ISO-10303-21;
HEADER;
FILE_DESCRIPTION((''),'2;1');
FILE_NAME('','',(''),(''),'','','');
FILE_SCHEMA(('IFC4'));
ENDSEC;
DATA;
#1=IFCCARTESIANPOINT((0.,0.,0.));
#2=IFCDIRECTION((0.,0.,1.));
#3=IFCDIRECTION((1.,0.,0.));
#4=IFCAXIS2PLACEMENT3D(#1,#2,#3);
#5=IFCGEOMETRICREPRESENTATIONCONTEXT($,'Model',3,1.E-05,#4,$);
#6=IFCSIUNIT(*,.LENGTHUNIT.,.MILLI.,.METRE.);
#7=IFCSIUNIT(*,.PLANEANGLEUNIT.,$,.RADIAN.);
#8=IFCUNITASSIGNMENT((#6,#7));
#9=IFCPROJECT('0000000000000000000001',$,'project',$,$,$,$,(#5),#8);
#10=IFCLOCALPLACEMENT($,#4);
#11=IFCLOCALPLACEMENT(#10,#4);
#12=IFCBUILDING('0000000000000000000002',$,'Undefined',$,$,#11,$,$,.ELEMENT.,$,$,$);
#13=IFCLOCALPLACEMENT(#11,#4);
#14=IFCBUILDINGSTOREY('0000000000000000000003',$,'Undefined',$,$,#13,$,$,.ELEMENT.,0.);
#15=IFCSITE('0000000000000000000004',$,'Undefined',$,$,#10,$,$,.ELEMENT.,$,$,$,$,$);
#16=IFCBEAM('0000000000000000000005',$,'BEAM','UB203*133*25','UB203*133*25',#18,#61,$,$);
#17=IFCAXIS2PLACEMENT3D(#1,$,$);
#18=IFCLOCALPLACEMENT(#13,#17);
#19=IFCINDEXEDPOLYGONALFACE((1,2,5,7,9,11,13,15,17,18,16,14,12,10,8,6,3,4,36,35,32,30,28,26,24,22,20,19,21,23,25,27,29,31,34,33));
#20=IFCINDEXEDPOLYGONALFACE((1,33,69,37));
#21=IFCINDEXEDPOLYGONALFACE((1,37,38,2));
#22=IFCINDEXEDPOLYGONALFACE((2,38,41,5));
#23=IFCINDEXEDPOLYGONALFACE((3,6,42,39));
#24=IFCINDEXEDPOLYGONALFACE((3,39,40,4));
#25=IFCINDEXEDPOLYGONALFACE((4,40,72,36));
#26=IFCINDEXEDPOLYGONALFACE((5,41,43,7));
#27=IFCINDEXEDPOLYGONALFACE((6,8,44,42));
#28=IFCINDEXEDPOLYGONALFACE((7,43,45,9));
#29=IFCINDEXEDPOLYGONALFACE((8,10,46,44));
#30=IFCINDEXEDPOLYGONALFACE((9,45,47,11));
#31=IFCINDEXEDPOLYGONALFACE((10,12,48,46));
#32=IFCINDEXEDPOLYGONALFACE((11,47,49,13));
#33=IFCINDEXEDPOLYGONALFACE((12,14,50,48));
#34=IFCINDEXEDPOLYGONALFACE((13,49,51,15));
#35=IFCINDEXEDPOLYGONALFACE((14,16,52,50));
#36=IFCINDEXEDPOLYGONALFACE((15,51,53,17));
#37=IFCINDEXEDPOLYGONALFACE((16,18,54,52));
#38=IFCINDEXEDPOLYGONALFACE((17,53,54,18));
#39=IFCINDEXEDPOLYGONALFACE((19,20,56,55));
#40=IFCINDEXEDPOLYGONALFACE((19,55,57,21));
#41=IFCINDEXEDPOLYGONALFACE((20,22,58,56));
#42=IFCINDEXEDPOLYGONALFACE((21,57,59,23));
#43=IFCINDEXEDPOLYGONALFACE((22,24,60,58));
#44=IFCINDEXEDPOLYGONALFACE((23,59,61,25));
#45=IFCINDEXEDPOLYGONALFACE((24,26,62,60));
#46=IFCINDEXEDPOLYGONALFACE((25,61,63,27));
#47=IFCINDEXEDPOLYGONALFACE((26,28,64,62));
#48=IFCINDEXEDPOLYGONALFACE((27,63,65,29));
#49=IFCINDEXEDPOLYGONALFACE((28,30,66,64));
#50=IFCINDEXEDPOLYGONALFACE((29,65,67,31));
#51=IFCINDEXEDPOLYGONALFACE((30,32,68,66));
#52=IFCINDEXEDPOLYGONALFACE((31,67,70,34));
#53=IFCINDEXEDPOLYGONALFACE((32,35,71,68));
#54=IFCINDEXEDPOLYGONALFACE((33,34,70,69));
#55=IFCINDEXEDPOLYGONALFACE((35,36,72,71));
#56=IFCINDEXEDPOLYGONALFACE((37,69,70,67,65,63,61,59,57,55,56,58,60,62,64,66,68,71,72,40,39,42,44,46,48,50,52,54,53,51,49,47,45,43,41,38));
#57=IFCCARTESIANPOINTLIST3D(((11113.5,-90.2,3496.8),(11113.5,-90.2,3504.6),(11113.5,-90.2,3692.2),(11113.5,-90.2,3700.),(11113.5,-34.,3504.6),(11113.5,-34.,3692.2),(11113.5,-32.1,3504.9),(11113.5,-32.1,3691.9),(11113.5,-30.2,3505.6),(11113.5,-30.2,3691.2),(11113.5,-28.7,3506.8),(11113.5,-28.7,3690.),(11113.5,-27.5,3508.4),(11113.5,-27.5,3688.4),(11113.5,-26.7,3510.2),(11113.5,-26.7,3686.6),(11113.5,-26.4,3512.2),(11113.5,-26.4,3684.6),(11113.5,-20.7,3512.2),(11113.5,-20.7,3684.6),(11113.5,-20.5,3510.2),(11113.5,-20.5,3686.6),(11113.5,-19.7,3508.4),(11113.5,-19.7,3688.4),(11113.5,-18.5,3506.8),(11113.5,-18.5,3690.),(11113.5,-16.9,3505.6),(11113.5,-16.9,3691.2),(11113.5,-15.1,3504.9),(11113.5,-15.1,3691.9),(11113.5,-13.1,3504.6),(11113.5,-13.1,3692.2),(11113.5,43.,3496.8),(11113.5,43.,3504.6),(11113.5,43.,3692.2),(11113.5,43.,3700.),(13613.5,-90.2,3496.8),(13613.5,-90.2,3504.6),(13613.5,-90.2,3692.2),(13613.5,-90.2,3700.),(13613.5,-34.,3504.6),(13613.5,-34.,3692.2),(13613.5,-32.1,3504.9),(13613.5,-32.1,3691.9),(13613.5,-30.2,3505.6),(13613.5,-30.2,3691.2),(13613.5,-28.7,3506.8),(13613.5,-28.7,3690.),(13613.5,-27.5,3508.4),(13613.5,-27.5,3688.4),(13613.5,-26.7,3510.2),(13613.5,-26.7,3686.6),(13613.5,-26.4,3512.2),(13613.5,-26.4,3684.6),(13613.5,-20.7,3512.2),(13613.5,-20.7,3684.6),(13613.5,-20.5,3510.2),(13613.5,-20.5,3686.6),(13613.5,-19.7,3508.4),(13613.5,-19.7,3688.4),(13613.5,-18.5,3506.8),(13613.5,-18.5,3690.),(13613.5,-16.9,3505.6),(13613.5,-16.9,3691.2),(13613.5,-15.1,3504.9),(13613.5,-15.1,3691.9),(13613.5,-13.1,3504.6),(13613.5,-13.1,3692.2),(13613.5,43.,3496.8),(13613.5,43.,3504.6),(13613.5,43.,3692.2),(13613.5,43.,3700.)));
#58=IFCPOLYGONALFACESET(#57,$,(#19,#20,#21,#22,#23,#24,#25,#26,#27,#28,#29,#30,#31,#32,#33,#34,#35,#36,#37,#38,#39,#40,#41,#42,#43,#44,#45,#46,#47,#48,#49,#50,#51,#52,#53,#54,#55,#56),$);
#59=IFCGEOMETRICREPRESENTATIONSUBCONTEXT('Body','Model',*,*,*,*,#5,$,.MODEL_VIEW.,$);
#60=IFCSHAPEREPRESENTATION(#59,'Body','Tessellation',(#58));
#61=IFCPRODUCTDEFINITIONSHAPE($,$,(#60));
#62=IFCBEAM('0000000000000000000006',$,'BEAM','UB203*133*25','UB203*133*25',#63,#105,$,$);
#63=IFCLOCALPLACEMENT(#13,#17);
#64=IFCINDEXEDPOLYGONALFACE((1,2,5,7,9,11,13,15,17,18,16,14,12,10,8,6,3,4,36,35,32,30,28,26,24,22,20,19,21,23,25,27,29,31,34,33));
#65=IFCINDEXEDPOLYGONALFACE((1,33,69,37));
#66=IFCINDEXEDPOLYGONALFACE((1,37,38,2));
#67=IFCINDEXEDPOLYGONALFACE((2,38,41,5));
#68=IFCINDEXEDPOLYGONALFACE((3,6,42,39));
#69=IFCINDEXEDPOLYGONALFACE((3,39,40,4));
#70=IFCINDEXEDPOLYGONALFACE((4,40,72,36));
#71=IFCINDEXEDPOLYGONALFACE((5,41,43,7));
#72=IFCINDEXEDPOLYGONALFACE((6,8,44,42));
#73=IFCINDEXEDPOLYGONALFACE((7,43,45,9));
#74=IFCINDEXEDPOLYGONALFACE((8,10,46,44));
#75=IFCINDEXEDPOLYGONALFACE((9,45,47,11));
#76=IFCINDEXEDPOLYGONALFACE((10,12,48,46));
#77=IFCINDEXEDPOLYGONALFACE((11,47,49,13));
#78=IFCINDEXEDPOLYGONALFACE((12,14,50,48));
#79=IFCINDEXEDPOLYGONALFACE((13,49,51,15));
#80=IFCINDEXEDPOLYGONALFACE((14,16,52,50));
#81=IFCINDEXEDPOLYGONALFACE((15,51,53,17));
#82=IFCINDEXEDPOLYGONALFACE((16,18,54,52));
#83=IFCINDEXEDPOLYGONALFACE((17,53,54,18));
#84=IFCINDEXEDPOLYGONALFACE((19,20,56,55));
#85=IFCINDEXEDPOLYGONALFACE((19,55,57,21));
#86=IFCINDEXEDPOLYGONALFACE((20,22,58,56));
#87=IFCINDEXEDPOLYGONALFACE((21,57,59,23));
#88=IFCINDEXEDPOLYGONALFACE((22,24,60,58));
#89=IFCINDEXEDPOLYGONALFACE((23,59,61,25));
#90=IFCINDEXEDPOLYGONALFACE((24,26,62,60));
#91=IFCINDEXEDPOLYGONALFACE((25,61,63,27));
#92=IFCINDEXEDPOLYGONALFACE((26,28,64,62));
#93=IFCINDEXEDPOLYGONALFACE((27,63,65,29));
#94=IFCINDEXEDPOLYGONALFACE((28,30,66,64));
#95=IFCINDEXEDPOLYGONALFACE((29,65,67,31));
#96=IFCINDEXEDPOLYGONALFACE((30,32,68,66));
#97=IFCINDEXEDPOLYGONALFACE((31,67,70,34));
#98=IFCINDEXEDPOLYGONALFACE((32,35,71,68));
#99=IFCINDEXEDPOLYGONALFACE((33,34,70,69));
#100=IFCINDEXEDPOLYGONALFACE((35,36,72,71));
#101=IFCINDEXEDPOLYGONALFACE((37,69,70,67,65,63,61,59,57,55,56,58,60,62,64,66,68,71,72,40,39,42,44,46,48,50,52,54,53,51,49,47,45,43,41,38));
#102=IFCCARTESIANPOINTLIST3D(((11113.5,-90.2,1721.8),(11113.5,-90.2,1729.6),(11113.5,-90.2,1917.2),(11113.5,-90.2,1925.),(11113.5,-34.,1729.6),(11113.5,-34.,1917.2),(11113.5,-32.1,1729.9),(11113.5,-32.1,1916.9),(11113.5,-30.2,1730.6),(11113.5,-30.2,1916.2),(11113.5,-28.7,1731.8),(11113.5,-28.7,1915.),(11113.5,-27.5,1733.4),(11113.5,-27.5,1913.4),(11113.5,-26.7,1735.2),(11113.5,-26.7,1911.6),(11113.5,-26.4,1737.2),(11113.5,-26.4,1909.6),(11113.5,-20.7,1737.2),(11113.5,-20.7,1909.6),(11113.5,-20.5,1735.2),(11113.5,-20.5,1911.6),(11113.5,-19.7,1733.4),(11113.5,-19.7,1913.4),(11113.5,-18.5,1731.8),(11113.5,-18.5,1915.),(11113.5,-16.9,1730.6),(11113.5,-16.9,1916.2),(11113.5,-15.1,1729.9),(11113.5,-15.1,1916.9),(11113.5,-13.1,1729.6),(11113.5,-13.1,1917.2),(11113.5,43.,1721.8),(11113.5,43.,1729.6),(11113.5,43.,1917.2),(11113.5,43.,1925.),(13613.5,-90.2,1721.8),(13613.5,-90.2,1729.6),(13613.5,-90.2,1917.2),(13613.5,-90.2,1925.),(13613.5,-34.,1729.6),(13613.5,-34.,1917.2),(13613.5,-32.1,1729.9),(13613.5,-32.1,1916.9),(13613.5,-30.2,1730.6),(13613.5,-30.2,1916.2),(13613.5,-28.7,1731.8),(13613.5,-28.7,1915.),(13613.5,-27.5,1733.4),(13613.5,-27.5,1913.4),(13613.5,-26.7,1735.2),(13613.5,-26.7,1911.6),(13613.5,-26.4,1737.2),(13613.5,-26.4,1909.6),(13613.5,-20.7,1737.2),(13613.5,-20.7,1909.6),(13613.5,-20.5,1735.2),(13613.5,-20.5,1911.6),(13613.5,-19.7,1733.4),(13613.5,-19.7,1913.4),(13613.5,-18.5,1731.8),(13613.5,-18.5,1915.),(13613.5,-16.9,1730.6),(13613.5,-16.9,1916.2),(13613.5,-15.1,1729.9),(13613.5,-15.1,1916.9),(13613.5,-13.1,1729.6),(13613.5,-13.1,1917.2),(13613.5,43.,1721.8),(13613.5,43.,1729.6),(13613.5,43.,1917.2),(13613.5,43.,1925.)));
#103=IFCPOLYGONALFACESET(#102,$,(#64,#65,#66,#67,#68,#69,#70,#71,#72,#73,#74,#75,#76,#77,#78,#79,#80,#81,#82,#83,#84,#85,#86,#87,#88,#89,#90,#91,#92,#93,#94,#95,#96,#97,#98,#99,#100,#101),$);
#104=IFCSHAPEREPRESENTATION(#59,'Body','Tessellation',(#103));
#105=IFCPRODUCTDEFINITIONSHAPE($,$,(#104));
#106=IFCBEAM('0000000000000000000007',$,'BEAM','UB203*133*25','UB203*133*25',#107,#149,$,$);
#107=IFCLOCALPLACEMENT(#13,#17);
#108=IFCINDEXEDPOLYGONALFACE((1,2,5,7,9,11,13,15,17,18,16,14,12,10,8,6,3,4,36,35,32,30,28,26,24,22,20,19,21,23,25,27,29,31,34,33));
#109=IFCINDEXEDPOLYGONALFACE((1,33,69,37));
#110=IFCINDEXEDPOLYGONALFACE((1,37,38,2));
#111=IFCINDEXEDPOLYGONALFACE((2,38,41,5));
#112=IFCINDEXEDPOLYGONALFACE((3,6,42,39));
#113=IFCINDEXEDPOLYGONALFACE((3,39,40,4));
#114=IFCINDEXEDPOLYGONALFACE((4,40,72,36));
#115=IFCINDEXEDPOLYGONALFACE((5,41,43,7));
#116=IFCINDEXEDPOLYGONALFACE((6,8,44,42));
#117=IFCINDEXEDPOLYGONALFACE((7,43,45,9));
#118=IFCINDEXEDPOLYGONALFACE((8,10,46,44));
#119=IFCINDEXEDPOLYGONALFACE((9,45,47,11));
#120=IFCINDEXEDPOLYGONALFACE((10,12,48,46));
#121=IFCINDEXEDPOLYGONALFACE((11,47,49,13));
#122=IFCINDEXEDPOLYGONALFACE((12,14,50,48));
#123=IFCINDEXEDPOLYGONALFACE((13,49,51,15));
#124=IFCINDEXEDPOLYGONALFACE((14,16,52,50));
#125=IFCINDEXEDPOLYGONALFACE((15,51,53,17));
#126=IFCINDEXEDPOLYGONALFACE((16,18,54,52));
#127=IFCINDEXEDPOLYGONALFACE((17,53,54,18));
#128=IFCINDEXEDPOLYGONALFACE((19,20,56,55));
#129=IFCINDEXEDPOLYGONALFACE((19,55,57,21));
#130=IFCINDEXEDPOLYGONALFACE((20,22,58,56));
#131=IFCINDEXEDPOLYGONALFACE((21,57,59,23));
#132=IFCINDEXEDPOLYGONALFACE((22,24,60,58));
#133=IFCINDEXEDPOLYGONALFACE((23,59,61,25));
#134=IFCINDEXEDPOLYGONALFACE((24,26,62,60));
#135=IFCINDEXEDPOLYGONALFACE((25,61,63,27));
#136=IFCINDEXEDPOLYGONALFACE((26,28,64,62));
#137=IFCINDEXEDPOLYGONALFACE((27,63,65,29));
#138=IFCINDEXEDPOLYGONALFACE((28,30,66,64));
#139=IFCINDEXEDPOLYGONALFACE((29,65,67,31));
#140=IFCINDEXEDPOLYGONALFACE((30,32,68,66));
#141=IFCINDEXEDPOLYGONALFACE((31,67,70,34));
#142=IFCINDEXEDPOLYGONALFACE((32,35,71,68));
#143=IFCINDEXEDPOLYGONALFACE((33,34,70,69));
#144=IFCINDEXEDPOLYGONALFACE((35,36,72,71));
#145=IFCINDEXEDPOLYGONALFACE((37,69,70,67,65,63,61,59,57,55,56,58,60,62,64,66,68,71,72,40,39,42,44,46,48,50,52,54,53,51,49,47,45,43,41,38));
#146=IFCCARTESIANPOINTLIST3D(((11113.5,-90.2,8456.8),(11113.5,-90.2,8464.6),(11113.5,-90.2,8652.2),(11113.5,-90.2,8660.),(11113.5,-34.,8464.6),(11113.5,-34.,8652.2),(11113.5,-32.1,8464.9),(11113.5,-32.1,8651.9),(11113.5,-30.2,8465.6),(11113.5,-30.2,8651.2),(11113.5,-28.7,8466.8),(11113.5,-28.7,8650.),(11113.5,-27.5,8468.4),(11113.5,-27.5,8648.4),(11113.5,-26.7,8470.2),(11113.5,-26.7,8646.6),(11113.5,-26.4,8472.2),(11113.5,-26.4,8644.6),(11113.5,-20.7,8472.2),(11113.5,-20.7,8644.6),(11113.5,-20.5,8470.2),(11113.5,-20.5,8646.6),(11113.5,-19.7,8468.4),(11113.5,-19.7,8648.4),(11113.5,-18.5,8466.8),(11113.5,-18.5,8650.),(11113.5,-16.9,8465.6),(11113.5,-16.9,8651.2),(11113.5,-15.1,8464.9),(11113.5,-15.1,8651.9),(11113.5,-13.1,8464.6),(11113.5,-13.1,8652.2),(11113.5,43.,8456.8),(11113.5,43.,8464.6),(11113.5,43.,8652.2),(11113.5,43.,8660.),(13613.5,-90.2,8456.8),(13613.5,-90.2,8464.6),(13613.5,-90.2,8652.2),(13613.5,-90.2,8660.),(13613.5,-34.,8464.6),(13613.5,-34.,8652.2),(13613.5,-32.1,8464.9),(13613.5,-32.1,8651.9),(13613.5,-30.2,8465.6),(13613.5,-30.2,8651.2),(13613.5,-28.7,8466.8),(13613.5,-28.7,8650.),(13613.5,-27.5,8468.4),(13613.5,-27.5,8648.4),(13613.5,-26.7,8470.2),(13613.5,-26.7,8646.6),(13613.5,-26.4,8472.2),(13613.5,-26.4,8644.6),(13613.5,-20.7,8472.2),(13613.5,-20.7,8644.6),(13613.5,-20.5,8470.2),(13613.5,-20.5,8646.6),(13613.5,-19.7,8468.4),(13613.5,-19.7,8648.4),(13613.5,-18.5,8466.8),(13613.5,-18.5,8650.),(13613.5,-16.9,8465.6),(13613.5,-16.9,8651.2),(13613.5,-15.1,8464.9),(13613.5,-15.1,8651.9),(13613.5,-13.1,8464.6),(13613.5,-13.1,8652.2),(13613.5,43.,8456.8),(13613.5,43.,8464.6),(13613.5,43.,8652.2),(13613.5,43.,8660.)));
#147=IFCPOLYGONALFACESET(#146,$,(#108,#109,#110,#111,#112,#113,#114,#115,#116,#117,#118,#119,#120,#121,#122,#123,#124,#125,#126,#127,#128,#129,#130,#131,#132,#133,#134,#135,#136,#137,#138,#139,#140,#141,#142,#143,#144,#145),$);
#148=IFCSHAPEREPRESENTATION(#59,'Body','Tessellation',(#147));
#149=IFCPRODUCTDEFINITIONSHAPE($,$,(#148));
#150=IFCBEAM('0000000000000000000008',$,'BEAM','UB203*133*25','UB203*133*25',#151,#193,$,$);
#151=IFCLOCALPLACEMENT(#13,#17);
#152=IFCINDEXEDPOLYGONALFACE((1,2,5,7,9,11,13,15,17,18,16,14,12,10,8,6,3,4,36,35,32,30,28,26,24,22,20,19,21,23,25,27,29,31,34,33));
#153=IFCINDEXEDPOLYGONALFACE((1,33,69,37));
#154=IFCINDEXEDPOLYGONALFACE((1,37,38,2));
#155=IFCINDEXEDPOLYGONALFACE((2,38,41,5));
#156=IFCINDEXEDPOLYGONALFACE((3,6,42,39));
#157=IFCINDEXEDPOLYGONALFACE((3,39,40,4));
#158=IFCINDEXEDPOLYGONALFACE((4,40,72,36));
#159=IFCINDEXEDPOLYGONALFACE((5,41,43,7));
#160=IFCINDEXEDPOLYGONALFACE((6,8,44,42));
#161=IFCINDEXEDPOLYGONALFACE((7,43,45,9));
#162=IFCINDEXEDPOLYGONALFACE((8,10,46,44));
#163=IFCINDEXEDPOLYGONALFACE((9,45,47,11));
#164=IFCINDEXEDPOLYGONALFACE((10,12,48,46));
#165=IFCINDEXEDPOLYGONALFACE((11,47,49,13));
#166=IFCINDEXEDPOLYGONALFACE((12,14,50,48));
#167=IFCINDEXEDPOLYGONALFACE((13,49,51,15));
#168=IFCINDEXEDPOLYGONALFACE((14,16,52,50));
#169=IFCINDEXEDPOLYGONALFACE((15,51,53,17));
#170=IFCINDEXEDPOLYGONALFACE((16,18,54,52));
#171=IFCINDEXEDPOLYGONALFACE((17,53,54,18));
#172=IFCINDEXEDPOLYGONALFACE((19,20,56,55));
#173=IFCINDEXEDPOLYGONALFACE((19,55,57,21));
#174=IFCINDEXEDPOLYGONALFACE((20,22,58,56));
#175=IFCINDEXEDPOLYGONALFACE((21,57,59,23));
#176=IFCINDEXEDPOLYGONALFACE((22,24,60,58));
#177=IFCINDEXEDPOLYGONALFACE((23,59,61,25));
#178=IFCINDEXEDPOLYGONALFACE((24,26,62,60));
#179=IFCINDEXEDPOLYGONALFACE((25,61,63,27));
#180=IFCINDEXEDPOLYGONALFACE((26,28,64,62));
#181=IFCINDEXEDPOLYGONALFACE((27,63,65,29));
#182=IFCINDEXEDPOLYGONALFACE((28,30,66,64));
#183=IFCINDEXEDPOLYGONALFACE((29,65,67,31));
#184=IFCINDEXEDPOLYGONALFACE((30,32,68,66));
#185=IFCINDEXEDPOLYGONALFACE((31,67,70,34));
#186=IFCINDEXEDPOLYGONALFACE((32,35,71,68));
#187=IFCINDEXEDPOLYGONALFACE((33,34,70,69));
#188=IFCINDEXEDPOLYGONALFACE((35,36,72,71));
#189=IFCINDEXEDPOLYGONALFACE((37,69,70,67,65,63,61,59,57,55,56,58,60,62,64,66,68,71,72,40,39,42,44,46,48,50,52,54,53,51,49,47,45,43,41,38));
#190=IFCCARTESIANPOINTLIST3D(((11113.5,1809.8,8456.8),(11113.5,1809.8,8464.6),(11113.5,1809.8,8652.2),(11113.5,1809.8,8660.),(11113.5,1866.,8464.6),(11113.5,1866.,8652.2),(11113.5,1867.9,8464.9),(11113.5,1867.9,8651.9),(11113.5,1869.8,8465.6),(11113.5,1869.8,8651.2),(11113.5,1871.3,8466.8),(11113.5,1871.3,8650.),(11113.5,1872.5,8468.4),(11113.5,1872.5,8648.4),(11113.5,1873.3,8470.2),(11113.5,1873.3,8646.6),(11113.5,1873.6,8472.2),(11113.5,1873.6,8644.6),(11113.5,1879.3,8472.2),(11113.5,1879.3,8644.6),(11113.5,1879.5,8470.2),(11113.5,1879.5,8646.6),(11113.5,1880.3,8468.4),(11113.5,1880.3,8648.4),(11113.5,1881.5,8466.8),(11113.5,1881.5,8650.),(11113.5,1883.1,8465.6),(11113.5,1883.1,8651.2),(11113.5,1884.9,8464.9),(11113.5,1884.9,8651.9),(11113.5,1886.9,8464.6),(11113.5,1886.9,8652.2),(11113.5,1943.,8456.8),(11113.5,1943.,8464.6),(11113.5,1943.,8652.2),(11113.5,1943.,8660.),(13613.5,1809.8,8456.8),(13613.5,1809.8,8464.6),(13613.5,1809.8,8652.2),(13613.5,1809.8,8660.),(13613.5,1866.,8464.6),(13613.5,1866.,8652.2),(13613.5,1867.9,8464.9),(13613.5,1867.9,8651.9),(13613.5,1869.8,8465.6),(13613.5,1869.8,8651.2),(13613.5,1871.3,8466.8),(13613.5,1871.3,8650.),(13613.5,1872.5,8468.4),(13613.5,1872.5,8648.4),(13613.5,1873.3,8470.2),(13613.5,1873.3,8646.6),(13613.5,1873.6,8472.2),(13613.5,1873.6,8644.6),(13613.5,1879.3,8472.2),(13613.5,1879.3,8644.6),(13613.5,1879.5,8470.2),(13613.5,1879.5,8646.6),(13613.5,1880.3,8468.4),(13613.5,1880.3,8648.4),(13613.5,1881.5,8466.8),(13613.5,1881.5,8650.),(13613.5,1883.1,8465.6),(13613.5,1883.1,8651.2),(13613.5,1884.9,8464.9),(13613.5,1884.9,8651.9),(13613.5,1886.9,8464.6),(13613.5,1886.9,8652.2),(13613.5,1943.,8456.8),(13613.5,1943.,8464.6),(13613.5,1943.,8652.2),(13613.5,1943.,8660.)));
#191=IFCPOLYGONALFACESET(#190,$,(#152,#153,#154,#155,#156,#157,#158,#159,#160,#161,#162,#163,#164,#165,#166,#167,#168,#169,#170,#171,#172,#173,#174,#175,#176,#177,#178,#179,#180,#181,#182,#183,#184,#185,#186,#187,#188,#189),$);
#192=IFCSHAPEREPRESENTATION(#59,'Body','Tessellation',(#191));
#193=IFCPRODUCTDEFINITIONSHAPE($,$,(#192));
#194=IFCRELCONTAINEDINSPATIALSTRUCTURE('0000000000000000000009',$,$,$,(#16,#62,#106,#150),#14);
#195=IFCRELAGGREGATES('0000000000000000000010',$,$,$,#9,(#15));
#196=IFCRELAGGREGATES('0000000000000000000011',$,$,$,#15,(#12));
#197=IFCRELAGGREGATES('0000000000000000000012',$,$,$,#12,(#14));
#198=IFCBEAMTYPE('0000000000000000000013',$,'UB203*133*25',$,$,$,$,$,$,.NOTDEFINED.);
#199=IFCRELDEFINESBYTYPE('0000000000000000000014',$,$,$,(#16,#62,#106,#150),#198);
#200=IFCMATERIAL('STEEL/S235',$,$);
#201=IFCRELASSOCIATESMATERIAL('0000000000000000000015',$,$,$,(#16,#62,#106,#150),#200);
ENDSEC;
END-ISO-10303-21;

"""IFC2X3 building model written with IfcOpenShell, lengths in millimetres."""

from ifc_helpers import new_model, si_unit, frame, origin_with_axes, origin_2d_with_axis, place, context, subcontext, project, spatial, i_section, extrude, material, type_object, element, save


model = new_model("IFC2X3")

# Units and contexts
model_context = context("Model", 3, precision=1e-05, world=origin_with_axes())
body_context = subcontext(model_context, "Body", "Model", "MODEL_VIEW")
ifc_project = project(units=[si_unit("LENGTHUNIT", "METRE", prefix="MILLI"), si_unit("PLANEANGLEUNIT", "RADIAN")], contexts=[model_context])

# Site, building, storey
site_placement = place(None, origin_with_axes())
site = spatial("IfcSite", under=ifc_project, at=site_placement, Name="Undefined", CompositionType="ELEMENT")
building_placement = place(site_placement, origin_with_axes())
building = spatial("IfcBuilding", under=site, at=building_placement, Name="Undefined", CompositionType="ELEMENT")
storey_placement = place(building_placement, origin_with_axes())
storey = spatial("IfcBuildingStorey", under=building, at=storey_placement, Name="Undefined", CompositionType="ELEMENT", Elevation=0.0)

# Shared definitions
ifc_material = material(Name="STEEL/S235")

# Beams
beam_type_1 = type_object("IfcBeamType", Name="UB203*133*25", PredefinedType="NOTDEFINED")
for number, where, z_axis, x_axis, name in (
    (1, (11113.5, -23.6, 3598.4), (0.0, 0.0, 1.0), (1.0, 0.0, 0.0), "BEAM"),
    (2, (11113.5, -23.6, 1823.4), (0.0, 0.0, 1.0), (1.0, 0.0, 0.0), "BEAM"),
    (3, (11113.5, -23.6, 8558.4), (0.0, 0.0, 1.0), (1.0, 0.0, 0.0), "BEAM"),
    (4, (11113.5, 1876.4, 8558.4), (0.0, 0.0, 1.0), (1.0, 0.0, 0.0), "BEAM"),
):
    element("IfcBeam", number, at=place(storey_placement, frame(where, z_axis=z_axis, x_axis=x_axis)), inside=storey, type_object=beam_type_1, material=ifc_material, Name=name, Description="UB203*133*25", ObjectType="UB203*133*25", context=body_context, shape_type="SweptSolid", body=[
        extrude(i_section(OverallWidth=133.2, OverallDepth=203.2, WebThickness=5.7, FlangeThickness=7.8, FilletRadius=7.6, at=origin_2d_with_axis()), frame((2500.0, 0.0, 0.0), z_axis=(-1.0, 0.0, 0.0), x_axis=(0.0, -1.0, 0.0)), (0.0, 0.0, 1.0), 2500.0),
    ])

save(model, "model.ifc")
